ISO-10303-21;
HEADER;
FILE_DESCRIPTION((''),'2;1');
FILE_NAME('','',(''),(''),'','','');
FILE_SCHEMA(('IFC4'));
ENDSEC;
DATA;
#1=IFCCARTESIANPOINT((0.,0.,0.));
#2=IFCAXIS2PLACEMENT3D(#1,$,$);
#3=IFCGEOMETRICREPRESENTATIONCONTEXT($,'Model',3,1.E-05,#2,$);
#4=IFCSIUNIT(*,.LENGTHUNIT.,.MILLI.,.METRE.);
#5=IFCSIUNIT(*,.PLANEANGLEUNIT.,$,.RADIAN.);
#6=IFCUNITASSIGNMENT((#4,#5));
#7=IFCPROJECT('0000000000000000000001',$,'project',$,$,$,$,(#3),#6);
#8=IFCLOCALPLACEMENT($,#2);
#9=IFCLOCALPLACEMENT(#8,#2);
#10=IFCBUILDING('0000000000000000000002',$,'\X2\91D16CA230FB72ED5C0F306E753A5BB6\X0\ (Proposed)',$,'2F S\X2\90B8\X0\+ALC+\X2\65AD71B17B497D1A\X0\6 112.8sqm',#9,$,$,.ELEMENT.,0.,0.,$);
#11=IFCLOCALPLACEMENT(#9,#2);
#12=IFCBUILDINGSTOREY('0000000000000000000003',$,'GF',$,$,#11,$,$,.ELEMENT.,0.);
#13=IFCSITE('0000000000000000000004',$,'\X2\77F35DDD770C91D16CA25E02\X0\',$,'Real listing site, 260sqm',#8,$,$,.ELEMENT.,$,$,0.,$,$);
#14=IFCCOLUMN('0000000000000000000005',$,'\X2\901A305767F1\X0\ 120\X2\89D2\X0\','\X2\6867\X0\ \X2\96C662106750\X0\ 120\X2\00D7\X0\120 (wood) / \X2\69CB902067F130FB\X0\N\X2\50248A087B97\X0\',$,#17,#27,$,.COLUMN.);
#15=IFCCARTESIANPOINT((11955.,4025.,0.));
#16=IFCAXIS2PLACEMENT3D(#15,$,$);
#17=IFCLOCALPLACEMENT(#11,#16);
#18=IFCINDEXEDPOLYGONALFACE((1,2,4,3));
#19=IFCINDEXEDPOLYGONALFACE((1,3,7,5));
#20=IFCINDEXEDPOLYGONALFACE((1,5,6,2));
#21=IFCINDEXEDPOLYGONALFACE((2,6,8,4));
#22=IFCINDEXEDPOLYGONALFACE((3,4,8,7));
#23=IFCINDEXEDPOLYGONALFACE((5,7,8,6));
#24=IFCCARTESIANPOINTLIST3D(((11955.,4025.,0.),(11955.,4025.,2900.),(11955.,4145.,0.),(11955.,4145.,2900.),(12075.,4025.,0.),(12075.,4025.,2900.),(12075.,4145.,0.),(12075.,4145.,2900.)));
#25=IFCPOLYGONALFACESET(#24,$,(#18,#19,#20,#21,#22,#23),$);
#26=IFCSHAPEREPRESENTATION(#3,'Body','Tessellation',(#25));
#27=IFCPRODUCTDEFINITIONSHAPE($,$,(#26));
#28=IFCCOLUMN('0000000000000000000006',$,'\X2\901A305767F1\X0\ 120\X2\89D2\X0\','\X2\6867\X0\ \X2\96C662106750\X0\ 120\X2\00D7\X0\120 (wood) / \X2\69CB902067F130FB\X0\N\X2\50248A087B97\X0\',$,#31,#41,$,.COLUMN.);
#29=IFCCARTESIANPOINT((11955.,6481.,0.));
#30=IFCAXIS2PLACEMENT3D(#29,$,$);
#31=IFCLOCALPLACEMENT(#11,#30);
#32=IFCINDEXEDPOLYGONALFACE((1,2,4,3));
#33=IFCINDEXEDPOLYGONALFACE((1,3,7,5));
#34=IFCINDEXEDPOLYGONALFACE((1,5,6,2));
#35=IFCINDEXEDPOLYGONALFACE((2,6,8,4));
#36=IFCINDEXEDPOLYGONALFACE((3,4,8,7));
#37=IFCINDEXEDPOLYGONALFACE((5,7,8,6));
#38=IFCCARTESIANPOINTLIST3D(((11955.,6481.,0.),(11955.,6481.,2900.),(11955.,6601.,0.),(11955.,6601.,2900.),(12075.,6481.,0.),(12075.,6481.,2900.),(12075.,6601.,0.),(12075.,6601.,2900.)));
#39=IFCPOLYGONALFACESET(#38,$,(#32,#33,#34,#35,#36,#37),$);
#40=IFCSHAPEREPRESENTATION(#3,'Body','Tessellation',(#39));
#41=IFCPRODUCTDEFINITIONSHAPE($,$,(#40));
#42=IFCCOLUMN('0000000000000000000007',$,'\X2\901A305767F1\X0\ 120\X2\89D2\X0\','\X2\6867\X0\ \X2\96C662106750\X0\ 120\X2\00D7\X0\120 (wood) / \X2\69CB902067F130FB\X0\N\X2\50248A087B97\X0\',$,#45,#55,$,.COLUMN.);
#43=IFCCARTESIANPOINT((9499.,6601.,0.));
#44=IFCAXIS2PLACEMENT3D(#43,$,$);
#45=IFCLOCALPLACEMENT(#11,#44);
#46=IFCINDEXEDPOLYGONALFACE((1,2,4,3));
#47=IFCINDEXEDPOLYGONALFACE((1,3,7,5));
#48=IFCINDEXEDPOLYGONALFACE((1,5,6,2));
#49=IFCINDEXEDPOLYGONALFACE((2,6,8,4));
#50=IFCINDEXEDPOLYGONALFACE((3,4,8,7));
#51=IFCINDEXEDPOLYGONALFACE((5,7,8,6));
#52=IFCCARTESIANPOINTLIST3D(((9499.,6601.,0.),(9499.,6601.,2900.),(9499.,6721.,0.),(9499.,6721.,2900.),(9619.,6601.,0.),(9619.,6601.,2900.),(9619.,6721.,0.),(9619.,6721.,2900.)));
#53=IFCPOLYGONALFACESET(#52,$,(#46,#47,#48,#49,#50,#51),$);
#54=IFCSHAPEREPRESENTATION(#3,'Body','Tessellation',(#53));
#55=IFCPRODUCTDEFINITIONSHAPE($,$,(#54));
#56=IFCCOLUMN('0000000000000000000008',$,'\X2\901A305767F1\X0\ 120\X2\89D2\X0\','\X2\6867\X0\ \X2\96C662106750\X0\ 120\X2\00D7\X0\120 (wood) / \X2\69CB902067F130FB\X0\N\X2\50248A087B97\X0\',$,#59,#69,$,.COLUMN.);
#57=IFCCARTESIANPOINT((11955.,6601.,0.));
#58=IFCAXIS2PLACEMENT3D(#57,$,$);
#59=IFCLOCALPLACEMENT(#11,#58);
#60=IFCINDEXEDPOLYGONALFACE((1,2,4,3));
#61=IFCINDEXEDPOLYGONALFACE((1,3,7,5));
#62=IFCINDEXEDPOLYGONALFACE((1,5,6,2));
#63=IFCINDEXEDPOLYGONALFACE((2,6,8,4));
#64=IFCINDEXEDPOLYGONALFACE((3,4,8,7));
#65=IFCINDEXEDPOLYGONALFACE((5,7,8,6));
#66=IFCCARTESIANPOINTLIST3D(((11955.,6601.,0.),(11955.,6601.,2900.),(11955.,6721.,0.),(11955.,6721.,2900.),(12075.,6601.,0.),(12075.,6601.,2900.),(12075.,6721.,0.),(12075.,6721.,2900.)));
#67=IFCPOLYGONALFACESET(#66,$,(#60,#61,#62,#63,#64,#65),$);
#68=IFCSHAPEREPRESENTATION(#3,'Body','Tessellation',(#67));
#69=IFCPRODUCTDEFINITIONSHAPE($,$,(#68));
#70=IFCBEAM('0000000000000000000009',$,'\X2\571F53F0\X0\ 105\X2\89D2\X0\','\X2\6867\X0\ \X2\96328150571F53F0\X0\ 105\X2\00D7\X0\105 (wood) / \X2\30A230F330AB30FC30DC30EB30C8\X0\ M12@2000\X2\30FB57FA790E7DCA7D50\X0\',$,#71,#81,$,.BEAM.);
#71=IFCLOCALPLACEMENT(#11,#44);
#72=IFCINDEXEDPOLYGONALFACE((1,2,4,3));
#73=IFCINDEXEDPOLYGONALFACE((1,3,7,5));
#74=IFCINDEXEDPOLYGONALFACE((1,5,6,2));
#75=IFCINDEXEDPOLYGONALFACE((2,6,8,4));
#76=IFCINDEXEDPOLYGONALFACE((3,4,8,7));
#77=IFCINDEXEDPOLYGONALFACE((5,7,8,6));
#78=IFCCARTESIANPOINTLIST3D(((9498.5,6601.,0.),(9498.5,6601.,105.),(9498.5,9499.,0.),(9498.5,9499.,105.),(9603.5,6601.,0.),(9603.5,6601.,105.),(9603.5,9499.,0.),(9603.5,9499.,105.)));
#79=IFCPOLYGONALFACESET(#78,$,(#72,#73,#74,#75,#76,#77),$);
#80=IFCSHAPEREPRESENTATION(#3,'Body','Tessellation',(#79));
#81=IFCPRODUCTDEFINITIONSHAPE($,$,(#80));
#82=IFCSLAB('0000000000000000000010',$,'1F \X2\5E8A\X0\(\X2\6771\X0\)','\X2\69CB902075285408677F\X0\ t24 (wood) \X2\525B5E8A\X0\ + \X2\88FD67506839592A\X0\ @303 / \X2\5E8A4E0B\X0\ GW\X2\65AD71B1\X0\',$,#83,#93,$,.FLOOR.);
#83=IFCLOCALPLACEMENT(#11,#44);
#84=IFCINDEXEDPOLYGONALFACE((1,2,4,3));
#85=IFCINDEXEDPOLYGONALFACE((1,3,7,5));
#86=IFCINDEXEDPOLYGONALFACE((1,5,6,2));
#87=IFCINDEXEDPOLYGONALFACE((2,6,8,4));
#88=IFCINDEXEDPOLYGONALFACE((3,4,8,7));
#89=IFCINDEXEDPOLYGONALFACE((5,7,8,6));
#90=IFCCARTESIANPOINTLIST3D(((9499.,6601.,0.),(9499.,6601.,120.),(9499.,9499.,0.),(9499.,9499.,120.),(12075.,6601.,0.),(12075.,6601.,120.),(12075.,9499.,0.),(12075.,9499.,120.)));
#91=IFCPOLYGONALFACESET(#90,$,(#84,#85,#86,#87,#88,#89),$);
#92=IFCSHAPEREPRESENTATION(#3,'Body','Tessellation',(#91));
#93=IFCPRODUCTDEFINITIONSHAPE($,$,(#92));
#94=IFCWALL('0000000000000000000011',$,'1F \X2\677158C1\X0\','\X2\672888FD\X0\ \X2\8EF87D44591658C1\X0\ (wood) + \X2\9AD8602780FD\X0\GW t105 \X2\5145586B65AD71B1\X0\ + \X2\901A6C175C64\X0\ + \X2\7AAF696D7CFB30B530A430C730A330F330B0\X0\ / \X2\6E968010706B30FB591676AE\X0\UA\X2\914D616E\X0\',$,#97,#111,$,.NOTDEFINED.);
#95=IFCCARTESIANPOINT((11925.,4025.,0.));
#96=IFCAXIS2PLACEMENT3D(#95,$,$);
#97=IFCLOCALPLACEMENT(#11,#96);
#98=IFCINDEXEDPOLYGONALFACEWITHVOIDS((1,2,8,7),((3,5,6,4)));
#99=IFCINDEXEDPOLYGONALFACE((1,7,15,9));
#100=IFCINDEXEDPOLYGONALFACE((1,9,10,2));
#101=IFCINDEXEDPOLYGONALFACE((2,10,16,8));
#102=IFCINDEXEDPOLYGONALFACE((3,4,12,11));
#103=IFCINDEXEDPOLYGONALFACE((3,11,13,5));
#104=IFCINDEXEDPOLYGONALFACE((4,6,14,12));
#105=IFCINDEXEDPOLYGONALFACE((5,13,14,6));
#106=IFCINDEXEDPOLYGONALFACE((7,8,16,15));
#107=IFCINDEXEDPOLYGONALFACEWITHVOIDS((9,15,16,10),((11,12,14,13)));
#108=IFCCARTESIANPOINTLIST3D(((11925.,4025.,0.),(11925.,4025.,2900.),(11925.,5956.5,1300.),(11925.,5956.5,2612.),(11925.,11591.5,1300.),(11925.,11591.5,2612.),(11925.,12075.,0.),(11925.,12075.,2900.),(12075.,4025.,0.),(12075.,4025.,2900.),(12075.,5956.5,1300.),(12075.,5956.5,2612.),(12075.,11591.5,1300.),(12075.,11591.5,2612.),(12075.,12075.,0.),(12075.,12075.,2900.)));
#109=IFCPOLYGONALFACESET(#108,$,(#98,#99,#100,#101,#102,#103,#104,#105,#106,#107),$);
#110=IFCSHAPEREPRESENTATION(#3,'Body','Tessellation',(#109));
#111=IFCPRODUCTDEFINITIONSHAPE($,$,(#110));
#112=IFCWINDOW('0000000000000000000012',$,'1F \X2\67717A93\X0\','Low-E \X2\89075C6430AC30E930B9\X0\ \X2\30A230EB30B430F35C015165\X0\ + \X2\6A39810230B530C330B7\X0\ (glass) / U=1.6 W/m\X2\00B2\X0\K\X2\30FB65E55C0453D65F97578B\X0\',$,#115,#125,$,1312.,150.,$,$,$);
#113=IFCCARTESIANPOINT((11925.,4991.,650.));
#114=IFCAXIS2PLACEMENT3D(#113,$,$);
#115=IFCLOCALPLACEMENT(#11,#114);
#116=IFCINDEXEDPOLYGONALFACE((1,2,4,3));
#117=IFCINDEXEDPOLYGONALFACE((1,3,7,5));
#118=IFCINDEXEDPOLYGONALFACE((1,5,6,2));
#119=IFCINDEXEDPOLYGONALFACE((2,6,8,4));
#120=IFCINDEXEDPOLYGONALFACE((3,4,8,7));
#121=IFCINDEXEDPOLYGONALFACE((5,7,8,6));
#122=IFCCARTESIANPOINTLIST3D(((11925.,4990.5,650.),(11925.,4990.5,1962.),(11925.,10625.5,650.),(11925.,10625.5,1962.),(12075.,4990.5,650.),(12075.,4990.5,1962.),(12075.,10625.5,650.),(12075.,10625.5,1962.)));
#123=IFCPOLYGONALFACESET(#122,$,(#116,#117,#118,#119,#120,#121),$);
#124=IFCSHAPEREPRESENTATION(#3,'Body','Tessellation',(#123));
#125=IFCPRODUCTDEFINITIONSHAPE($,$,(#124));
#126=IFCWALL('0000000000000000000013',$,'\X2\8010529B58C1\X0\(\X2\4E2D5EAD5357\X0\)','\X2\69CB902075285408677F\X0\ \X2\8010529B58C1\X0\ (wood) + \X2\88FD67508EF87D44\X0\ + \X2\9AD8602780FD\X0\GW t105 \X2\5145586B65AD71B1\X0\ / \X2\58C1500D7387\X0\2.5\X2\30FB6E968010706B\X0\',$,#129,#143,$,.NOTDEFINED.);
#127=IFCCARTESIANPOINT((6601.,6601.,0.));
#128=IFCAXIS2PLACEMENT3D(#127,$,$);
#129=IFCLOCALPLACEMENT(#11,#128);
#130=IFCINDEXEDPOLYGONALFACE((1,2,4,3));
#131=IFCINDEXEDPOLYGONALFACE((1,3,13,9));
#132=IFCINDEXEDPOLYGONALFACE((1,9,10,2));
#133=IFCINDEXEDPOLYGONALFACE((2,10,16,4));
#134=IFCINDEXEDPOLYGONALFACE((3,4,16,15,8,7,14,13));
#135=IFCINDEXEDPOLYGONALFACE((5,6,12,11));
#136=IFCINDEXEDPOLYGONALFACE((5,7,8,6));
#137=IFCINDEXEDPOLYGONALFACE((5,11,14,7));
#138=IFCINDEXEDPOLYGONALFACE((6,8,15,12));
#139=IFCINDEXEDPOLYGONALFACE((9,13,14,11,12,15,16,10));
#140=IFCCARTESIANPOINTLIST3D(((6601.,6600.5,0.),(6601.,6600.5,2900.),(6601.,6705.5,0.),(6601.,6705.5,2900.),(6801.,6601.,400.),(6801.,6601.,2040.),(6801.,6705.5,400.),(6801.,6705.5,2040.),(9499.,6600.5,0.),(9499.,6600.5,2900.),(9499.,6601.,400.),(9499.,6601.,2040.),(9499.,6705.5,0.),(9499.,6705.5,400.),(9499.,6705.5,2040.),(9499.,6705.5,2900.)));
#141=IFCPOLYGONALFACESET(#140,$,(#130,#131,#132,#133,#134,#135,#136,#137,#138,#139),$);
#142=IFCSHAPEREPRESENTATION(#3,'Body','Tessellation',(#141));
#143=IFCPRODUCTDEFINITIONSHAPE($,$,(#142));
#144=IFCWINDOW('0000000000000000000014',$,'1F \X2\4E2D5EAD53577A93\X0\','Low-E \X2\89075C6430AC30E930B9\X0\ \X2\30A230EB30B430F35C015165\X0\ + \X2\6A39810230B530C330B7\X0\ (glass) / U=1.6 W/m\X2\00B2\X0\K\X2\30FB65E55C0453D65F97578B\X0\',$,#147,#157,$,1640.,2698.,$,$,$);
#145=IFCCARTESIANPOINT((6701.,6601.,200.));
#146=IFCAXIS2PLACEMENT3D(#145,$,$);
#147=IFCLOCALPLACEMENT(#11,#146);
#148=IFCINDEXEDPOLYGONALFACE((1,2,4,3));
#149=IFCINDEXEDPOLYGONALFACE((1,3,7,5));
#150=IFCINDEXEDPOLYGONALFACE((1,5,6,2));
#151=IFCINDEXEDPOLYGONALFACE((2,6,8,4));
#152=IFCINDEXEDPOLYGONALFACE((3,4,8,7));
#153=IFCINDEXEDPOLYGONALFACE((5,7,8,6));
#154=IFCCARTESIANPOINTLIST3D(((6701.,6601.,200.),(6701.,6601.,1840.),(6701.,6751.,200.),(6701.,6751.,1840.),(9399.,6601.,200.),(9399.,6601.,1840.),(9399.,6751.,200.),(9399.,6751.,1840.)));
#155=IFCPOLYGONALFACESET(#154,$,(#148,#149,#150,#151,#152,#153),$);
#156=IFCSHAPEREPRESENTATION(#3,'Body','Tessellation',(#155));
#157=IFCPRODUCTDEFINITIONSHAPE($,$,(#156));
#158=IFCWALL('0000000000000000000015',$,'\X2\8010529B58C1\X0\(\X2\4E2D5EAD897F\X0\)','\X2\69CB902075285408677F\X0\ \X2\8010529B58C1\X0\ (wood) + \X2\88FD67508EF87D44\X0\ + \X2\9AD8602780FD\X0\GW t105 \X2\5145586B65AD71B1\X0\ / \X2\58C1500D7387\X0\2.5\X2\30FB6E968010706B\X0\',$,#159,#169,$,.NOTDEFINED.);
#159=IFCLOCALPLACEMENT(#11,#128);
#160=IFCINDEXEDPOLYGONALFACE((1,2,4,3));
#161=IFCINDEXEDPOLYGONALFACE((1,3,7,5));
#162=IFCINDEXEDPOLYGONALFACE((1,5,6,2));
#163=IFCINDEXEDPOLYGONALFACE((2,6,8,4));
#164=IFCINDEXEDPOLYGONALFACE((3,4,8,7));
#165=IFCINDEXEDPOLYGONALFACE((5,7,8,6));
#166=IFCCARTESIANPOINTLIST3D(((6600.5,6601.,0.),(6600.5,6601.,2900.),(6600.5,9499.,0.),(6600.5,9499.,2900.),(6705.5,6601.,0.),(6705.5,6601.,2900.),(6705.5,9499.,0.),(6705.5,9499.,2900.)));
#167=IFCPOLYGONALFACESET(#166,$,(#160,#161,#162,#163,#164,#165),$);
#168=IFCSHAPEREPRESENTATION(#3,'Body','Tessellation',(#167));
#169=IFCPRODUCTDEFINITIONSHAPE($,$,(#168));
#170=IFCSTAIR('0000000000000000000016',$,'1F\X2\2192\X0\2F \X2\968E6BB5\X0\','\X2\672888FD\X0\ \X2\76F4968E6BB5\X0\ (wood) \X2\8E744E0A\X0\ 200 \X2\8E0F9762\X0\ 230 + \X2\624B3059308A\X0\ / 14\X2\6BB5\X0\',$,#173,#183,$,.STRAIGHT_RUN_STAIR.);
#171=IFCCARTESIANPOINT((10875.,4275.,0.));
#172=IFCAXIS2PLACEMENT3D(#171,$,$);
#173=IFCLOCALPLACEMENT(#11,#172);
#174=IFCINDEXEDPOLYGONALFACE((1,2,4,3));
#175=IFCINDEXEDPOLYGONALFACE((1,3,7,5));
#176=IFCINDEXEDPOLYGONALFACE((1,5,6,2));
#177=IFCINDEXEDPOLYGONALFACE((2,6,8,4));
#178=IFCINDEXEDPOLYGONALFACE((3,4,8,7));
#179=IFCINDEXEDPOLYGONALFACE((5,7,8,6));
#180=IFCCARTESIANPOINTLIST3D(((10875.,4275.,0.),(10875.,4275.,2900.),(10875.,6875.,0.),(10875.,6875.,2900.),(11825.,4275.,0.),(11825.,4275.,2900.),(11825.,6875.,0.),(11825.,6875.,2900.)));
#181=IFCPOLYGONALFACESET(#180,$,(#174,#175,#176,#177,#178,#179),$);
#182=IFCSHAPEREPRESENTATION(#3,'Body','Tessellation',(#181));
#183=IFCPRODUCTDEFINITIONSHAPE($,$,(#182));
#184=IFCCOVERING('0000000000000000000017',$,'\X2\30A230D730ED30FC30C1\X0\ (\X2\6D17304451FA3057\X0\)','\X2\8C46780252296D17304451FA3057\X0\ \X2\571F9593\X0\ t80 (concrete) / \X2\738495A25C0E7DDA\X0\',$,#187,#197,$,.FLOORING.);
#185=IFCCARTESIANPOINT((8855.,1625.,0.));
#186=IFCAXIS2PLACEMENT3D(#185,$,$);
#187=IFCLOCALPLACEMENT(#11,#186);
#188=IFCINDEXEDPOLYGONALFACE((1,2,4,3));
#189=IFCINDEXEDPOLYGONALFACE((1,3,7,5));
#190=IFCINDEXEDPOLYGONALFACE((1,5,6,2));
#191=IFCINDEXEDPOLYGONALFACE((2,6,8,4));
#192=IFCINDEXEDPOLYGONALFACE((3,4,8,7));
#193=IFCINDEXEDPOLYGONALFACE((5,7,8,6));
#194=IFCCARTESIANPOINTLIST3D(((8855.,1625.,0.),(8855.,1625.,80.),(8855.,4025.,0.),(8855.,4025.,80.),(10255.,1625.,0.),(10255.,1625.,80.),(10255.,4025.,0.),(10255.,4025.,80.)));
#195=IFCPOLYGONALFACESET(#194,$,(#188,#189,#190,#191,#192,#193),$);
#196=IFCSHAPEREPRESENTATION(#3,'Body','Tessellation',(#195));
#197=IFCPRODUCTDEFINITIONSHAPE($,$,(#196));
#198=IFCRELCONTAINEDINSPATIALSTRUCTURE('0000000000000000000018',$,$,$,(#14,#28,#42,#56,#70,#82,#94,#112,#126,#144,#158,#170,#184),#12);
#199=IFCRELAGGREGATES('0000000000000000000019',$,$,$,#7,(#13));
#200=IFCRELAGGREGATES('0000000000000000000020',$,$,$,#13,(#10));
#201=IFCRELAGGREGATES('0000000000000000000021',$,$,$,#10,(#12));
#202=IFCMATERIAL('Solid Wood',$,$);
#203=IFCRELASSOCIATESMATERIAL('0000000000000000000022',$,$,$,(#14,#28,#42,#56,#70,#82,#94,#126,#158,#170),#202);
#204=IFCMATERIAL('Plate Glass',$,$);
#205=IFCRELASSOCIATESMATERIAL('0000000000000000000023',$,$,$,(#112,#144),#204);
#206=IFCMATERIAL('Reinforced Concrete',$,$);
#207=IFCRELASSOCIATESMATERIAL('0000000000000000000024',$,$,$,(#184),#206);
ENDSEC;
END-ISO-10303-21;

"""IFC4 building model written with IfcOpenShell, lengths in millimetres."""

from ifc_helpers import new_model, si_unit, frame, frame_2d, origin, place, context, project, spatial, rectangle, extrude, material, element, fill, save


model = new_model("IFC4")

# Units and contexts
model_context = context("Model", 3, precision=1e-05, world=origin())
ifc_project = project(units=[si_unit("LENGTHUNIT", "METRE", prefix="MILLI"), si_unit("PLANEANGLEUNIT", "RADIAN")], contexts=[model_context])

# Site, building, storey
site_placement = place(None, origin())
site = spatial("IfcSite", under=ifc_project, at=site_placement, Name="石川県金沢市", ObjectType="Real listing site, 260sqm", CompositionType="ELEMENT", RefElevation=0.0)
building_placement = place(site_placement, origin())
building = spatial("IfcBuilding", under=site, at=building_placement, Name="金沢・狭小の町家 (Proposed)", ObjectType="2F S邸+ALC+断熱等級6 112.8sqm", CompositionType="ELEMENT", ElevationOfRefHeight=0.0, ElevationOfTerrain=0.0)
storey_placement = place(building_placement, origin())
storey = spatial("IfcBuildingStorey", under=building, at=storey_placement, Name="GF", CompositionType="ELEMENT", Elevation=0.0)

# Columns
ifc_material_1 = material(Name="Solid Wood")
column_1_placement = place(storey_placement, frame((11955.0, 4025.0, 0.0)))
element("IfcColumn", 1, at=column_1_placement, inside=storey, material=ifc_material_1, Name="通し柱 120角", Description="桧 集成材 120×120 (wood) / 構造柱・N値計算", PredefinedType="COLUMN", context=model_context, shape_type="SweptSolid", body=[
    extrude(rectangle(XDim=120.0, YDim=120.0, at=frame_2d((60.0, 60.0))), frame((11955.0, 4025.0, 0.0)), (0.0, 0.0, 1.0), 2900.0),
])
column_2_placement = place(storey_placement, frame((11955.0, 6481.0, 0.0)))
element("IfcColumn", 2, at=column_2_placement, inside=storey, material=ifc_material_1, Name="通し柱 120角", Description="桧 集成材 120×120 (wood) / 構造柱・N値計算", PredefinedType="COLUMN", context=model_context, shape_type="SweptSolid", body=[
    extrude(rectangle(XDim=120.0, YDim=120.0, at=frame_2d((60.0, 60.0))), frame((11955.0, 6481.0, 0.0)), (0.0, 0.0, 1.0), 2900.0),
])
column_3_placement = place(storey_placement, frame((9499.0, 6601.0, 0.0)))
element("IfcColumn", 3, at=column_3_placement, inside=storey, material=ifc_material_1, Name="通し柱 120角", Description="桧 集成材 120×120 (wood) / 構造柱・N値計算", PredefinedType="COLUMN", context=model_context, shape_type="SweptSolid", body=[
    extrude(rectangle(XDim=120.0, YDim=120.0, at=frame_2d((60.0, 60.0))), frame((9499.0, 6601.0, 0.0)), (0.0, 0.0, 1.0), 2900.0),
])
column_4_placement = place(storey_placement, frame((11955.0, 6601.0, 0.0)))
element("IfcColumn", 4, at=column_4_placement, inside=storey, material=ifc_material_1, Name="通し柱 120角", Description="桧 集成材 120×120 (wood) / 構造柱・N値計算", PredefinedType="COLUMN", context=model_context, shape_type="SweptSolid", body=[
    extrude(rectangle(XDim=120.0, YDim=120.0, at=frame_2d((60.0, 60.0))), frame((11955.0, 6601.0, 0.0)), (0.0, 0.0, 1.0), 2900.0),
])

# Beam
beam_1_placement = place(storey_placement, frame((9499.0, 6601.0, 0.0)))
element("IfcBeam", 5, at=beam_1_placement, inside=storey, material=ifc_material_1, Name="土台 105角", Description="桧 防腐土台 105×105 (wood) / アンカーボルト M12@2000・基礎緊結", PredefinedType="BEAM", context=model_context, shape_type="SweptSolid", body=[
    extrude(rectangle(XDim=105.0, YDim=2898.0, at=frame_2d((52.0, 1449.0))), frame((9499.0, 6601.0, 0.0)), (0.0, 0.0, 1.0), 105.0),
])

# Slab
slab_placement = place(storey_placement, frame((9499.0, 6601.0, 0.0)))
element("IfcSlab", 6, at=slab_placement, inside=storey, material=ifc_material_1, Name="1F 床(東)", Description="構造用合板 t24 (wood) 剛床 + 製材根太 @303 / 床下 GW断熱", PredefinedType="FLOOR", context=model_context, shape_type="SweptSolid", body=[
    extrude(rectangle(XDim=2576.0, YDim=2898.0, at=frame_2d((1288.0, 1449.0))), frame((9499.0, 6601.0, 0.0)), (0.0, 0.0, 1.0), 120.0),
])

# Walls, openings, windows
wall_1_placement = place(storey_placement, frame((11925.0, 4025.0, 0.0)))
wall_1 = element("IfcWall", 7, at=wall_1_placement, inside=storey, material=ifc_material_1, Name="1F 東壁", Description="木製 軸組外壁 (wood) + 高性能GW t105 充填断熱 + 通気層 + 窯業系サイディング / 準耐火・外皮UA配慮", PredefinedType="NOTDEFINED", context=model_context, shape_type="SweptSolid", body=[
    extrude(rectangle(XDim=150.0, YDim=8050.0, at=frame_2d((75.0, 4025.0))), frame((11925.0, 4025.0, 0.0)), (0.0, 0.0, 1.0), 2900.0),
])
opening_1_placement = place(storey_placement, frame((11925.0, 4991.0, 650.0)))
opening_1 = element("IfcOpeningElement", 8, at=opening_1_placement, cuts=wall_1, PredefinedType="NOTDEFINED", context=model_context, shape_type="SweptSolid", body=[
    extrude(rectangle(XDim=150.0, YDim=5635.0, at=frame_2d((75.0, 2817.0))), frame((11925.0, 4991.0, 650.0)), (0.0, 0.0, 1.0), 1312.0),
])
ifc_material_2 = material(Name="Plate Glass")
window_1_placement = place(storey_placement, frame((11925.0, 4991.0, 650.0)))
window_1 = element("IfcWindow", 9, at=window_1_placement, inside=storey, material=ifc_material_2, Name="1F 東窓", Description="Low-E 複層ガラス アルゴン封入 + 樹脂サッシ (glass) / U=1.6 W/m²K・日射取得型", OverallHeight=1312.0, OverallWidth=150.0, context=model_context, shape_type="SweptSolid", body=[
    extrude(rectangle(XDim=150.0, YDim=5635.0, at=frame_2d((75.0, 2817.0))), frame((11925.0, 4991.0, 650.0)), (0.0, 0.0, 1.0), 1312.0),
])
fill(opening_1, window_1)
wall_2_placement = place(storey_placement, frame((6601.0, 6601.0, 0.0)))
wall_2 = element("IfcWall", 10, at=wall_2_placement, inside=storey, material=ifc_material_1, Name="耐力壁(中庭南)", Description="構造用合板 耐力壁 (wood) + 製材軸組 + 高性能GW t105 充填断熱 / 壁倍率2.5・準耐火", PredefinedType="NOTDEFINED", context=model_context, shape_type="SweptSolid", body=[
    extrude(rectangle(XDim=2898.0, YDim=105.0, at=frame_2d((1449.0, 52.0))), frame((6601.0, 6601.0, 0.0)), (0.0, 0.0, 1.0), 2900.0),
])
opening_2_placement = place(storey_placement, frame((6701.0, 6601.0, 200.0)))
opening_2 = element("IfcOpeningElement", 11, at=opening_2_placement, cuts=wall_2, PredefinedType="NOTDEFINED", context=model_context, shape_type="SweptSolid", body=[
    extrude(rectangle(XDim=2698.0, YDim=150.0, at=frame_2d((1349.0, 75.0))), frame((6701.0, 6601.0, 200.0)), (0.0, 0.0, 1.0), 1640.0),
])
window_2_placement = place(storey_placement, frame((6701.0, 6601.0, 200.0)))
window_2 = element("IfcWindow", 12, at=window_2_placement, inside=storey, material=ifc_material_2, Name="1F 中庭南窓", Description="Low-E 複層ガラス アルゴン封入 + 樹脂サッシ (glass) / U=1.6 W/m²K・日射取得型", OverallHeight=1640.0, OverallWidth=2698.0, context=model_context, shape_type="SweptSolid", body=[
    extrude(rectangle(XDim=2698.0, YDim=150.0, at=frame_2d((1349.0, 75.0))), frame((6701.0, 6601.0, 200.0)), (0.0, 0.0, 1.0), 1640.0),
])
fill(opening_2, window_2)

# Wall
wall_3_placement = place(storey_placement, frame((6601.0, 6601.0, 0.0)))
element("IfcWall", 13, at=wall_3_placement, inside=storey, material=ifc_material_1, Name="耐力壁(中庭西)", Description="構造用合板 耐力壁 (wood) + 製材軸組 + 高性能GW t105 充填断熱 / 壁倍率2.5・準耐火", PredefinedType="NOTDEFINED", context=model_context, shape_type="SweptSolid", body=[
    extrude(rectangle(XDim=105.0, YDim=2898.0, at=frame_2d((52.0, 1449.0))), frame((6601.0, 6601.0, 0.0)), (0.0, 0.0, 1.0), 2900.0),
])

# Stair
stair_placement = place(storey_placement, frame((10875.0, 4275.0, 0.0)))
element("IfcStair", 14, at=stair_placement, inside=storey, material=ifc_material_1, Name="1F→2F 階段", Description="木製 直階段 (wood) 蹴上 200 踏面 230 + 手すり / 14段", PredefinedType="STRAIGHT_RUN_STAIR", context=model_context, shape_type="SweptSolid", body=[
    extrude(rectangle(XDim=950.0, YDim=2600.0, at=frame_2d((475.0, 1300.0))), frame((10875.0, 4275.0, 0.0)), (0.0, 0.0, 1.0), 2900.0),
])

# Covering
ifc_material_3 = material(Name="Reinforced Concrete")
covering_placement = place(storey_placement, frame((8855.0, 1625.0, 0.0)))
element("IfcCovering", 15, at=covering_placement, inside=storey, material=ifc_material_3, Name="アプローチ (洗い出し)", Description="豆砂利洗い出し 土間 t80 (concrete) / 玄関導線", PredefinedType="FLOORING", context=model_context, shape_type="SweptSolid", body=[
    extrude(rectangle(XDim=1400.0, YDim=2400.0, at=frame_2d((700.0, 1200.0))), frame((8855.0, 1625.0, 0.0)), (0.0, 0.0, 1.0), 80.0),
])

save(model, "model.ifc")
